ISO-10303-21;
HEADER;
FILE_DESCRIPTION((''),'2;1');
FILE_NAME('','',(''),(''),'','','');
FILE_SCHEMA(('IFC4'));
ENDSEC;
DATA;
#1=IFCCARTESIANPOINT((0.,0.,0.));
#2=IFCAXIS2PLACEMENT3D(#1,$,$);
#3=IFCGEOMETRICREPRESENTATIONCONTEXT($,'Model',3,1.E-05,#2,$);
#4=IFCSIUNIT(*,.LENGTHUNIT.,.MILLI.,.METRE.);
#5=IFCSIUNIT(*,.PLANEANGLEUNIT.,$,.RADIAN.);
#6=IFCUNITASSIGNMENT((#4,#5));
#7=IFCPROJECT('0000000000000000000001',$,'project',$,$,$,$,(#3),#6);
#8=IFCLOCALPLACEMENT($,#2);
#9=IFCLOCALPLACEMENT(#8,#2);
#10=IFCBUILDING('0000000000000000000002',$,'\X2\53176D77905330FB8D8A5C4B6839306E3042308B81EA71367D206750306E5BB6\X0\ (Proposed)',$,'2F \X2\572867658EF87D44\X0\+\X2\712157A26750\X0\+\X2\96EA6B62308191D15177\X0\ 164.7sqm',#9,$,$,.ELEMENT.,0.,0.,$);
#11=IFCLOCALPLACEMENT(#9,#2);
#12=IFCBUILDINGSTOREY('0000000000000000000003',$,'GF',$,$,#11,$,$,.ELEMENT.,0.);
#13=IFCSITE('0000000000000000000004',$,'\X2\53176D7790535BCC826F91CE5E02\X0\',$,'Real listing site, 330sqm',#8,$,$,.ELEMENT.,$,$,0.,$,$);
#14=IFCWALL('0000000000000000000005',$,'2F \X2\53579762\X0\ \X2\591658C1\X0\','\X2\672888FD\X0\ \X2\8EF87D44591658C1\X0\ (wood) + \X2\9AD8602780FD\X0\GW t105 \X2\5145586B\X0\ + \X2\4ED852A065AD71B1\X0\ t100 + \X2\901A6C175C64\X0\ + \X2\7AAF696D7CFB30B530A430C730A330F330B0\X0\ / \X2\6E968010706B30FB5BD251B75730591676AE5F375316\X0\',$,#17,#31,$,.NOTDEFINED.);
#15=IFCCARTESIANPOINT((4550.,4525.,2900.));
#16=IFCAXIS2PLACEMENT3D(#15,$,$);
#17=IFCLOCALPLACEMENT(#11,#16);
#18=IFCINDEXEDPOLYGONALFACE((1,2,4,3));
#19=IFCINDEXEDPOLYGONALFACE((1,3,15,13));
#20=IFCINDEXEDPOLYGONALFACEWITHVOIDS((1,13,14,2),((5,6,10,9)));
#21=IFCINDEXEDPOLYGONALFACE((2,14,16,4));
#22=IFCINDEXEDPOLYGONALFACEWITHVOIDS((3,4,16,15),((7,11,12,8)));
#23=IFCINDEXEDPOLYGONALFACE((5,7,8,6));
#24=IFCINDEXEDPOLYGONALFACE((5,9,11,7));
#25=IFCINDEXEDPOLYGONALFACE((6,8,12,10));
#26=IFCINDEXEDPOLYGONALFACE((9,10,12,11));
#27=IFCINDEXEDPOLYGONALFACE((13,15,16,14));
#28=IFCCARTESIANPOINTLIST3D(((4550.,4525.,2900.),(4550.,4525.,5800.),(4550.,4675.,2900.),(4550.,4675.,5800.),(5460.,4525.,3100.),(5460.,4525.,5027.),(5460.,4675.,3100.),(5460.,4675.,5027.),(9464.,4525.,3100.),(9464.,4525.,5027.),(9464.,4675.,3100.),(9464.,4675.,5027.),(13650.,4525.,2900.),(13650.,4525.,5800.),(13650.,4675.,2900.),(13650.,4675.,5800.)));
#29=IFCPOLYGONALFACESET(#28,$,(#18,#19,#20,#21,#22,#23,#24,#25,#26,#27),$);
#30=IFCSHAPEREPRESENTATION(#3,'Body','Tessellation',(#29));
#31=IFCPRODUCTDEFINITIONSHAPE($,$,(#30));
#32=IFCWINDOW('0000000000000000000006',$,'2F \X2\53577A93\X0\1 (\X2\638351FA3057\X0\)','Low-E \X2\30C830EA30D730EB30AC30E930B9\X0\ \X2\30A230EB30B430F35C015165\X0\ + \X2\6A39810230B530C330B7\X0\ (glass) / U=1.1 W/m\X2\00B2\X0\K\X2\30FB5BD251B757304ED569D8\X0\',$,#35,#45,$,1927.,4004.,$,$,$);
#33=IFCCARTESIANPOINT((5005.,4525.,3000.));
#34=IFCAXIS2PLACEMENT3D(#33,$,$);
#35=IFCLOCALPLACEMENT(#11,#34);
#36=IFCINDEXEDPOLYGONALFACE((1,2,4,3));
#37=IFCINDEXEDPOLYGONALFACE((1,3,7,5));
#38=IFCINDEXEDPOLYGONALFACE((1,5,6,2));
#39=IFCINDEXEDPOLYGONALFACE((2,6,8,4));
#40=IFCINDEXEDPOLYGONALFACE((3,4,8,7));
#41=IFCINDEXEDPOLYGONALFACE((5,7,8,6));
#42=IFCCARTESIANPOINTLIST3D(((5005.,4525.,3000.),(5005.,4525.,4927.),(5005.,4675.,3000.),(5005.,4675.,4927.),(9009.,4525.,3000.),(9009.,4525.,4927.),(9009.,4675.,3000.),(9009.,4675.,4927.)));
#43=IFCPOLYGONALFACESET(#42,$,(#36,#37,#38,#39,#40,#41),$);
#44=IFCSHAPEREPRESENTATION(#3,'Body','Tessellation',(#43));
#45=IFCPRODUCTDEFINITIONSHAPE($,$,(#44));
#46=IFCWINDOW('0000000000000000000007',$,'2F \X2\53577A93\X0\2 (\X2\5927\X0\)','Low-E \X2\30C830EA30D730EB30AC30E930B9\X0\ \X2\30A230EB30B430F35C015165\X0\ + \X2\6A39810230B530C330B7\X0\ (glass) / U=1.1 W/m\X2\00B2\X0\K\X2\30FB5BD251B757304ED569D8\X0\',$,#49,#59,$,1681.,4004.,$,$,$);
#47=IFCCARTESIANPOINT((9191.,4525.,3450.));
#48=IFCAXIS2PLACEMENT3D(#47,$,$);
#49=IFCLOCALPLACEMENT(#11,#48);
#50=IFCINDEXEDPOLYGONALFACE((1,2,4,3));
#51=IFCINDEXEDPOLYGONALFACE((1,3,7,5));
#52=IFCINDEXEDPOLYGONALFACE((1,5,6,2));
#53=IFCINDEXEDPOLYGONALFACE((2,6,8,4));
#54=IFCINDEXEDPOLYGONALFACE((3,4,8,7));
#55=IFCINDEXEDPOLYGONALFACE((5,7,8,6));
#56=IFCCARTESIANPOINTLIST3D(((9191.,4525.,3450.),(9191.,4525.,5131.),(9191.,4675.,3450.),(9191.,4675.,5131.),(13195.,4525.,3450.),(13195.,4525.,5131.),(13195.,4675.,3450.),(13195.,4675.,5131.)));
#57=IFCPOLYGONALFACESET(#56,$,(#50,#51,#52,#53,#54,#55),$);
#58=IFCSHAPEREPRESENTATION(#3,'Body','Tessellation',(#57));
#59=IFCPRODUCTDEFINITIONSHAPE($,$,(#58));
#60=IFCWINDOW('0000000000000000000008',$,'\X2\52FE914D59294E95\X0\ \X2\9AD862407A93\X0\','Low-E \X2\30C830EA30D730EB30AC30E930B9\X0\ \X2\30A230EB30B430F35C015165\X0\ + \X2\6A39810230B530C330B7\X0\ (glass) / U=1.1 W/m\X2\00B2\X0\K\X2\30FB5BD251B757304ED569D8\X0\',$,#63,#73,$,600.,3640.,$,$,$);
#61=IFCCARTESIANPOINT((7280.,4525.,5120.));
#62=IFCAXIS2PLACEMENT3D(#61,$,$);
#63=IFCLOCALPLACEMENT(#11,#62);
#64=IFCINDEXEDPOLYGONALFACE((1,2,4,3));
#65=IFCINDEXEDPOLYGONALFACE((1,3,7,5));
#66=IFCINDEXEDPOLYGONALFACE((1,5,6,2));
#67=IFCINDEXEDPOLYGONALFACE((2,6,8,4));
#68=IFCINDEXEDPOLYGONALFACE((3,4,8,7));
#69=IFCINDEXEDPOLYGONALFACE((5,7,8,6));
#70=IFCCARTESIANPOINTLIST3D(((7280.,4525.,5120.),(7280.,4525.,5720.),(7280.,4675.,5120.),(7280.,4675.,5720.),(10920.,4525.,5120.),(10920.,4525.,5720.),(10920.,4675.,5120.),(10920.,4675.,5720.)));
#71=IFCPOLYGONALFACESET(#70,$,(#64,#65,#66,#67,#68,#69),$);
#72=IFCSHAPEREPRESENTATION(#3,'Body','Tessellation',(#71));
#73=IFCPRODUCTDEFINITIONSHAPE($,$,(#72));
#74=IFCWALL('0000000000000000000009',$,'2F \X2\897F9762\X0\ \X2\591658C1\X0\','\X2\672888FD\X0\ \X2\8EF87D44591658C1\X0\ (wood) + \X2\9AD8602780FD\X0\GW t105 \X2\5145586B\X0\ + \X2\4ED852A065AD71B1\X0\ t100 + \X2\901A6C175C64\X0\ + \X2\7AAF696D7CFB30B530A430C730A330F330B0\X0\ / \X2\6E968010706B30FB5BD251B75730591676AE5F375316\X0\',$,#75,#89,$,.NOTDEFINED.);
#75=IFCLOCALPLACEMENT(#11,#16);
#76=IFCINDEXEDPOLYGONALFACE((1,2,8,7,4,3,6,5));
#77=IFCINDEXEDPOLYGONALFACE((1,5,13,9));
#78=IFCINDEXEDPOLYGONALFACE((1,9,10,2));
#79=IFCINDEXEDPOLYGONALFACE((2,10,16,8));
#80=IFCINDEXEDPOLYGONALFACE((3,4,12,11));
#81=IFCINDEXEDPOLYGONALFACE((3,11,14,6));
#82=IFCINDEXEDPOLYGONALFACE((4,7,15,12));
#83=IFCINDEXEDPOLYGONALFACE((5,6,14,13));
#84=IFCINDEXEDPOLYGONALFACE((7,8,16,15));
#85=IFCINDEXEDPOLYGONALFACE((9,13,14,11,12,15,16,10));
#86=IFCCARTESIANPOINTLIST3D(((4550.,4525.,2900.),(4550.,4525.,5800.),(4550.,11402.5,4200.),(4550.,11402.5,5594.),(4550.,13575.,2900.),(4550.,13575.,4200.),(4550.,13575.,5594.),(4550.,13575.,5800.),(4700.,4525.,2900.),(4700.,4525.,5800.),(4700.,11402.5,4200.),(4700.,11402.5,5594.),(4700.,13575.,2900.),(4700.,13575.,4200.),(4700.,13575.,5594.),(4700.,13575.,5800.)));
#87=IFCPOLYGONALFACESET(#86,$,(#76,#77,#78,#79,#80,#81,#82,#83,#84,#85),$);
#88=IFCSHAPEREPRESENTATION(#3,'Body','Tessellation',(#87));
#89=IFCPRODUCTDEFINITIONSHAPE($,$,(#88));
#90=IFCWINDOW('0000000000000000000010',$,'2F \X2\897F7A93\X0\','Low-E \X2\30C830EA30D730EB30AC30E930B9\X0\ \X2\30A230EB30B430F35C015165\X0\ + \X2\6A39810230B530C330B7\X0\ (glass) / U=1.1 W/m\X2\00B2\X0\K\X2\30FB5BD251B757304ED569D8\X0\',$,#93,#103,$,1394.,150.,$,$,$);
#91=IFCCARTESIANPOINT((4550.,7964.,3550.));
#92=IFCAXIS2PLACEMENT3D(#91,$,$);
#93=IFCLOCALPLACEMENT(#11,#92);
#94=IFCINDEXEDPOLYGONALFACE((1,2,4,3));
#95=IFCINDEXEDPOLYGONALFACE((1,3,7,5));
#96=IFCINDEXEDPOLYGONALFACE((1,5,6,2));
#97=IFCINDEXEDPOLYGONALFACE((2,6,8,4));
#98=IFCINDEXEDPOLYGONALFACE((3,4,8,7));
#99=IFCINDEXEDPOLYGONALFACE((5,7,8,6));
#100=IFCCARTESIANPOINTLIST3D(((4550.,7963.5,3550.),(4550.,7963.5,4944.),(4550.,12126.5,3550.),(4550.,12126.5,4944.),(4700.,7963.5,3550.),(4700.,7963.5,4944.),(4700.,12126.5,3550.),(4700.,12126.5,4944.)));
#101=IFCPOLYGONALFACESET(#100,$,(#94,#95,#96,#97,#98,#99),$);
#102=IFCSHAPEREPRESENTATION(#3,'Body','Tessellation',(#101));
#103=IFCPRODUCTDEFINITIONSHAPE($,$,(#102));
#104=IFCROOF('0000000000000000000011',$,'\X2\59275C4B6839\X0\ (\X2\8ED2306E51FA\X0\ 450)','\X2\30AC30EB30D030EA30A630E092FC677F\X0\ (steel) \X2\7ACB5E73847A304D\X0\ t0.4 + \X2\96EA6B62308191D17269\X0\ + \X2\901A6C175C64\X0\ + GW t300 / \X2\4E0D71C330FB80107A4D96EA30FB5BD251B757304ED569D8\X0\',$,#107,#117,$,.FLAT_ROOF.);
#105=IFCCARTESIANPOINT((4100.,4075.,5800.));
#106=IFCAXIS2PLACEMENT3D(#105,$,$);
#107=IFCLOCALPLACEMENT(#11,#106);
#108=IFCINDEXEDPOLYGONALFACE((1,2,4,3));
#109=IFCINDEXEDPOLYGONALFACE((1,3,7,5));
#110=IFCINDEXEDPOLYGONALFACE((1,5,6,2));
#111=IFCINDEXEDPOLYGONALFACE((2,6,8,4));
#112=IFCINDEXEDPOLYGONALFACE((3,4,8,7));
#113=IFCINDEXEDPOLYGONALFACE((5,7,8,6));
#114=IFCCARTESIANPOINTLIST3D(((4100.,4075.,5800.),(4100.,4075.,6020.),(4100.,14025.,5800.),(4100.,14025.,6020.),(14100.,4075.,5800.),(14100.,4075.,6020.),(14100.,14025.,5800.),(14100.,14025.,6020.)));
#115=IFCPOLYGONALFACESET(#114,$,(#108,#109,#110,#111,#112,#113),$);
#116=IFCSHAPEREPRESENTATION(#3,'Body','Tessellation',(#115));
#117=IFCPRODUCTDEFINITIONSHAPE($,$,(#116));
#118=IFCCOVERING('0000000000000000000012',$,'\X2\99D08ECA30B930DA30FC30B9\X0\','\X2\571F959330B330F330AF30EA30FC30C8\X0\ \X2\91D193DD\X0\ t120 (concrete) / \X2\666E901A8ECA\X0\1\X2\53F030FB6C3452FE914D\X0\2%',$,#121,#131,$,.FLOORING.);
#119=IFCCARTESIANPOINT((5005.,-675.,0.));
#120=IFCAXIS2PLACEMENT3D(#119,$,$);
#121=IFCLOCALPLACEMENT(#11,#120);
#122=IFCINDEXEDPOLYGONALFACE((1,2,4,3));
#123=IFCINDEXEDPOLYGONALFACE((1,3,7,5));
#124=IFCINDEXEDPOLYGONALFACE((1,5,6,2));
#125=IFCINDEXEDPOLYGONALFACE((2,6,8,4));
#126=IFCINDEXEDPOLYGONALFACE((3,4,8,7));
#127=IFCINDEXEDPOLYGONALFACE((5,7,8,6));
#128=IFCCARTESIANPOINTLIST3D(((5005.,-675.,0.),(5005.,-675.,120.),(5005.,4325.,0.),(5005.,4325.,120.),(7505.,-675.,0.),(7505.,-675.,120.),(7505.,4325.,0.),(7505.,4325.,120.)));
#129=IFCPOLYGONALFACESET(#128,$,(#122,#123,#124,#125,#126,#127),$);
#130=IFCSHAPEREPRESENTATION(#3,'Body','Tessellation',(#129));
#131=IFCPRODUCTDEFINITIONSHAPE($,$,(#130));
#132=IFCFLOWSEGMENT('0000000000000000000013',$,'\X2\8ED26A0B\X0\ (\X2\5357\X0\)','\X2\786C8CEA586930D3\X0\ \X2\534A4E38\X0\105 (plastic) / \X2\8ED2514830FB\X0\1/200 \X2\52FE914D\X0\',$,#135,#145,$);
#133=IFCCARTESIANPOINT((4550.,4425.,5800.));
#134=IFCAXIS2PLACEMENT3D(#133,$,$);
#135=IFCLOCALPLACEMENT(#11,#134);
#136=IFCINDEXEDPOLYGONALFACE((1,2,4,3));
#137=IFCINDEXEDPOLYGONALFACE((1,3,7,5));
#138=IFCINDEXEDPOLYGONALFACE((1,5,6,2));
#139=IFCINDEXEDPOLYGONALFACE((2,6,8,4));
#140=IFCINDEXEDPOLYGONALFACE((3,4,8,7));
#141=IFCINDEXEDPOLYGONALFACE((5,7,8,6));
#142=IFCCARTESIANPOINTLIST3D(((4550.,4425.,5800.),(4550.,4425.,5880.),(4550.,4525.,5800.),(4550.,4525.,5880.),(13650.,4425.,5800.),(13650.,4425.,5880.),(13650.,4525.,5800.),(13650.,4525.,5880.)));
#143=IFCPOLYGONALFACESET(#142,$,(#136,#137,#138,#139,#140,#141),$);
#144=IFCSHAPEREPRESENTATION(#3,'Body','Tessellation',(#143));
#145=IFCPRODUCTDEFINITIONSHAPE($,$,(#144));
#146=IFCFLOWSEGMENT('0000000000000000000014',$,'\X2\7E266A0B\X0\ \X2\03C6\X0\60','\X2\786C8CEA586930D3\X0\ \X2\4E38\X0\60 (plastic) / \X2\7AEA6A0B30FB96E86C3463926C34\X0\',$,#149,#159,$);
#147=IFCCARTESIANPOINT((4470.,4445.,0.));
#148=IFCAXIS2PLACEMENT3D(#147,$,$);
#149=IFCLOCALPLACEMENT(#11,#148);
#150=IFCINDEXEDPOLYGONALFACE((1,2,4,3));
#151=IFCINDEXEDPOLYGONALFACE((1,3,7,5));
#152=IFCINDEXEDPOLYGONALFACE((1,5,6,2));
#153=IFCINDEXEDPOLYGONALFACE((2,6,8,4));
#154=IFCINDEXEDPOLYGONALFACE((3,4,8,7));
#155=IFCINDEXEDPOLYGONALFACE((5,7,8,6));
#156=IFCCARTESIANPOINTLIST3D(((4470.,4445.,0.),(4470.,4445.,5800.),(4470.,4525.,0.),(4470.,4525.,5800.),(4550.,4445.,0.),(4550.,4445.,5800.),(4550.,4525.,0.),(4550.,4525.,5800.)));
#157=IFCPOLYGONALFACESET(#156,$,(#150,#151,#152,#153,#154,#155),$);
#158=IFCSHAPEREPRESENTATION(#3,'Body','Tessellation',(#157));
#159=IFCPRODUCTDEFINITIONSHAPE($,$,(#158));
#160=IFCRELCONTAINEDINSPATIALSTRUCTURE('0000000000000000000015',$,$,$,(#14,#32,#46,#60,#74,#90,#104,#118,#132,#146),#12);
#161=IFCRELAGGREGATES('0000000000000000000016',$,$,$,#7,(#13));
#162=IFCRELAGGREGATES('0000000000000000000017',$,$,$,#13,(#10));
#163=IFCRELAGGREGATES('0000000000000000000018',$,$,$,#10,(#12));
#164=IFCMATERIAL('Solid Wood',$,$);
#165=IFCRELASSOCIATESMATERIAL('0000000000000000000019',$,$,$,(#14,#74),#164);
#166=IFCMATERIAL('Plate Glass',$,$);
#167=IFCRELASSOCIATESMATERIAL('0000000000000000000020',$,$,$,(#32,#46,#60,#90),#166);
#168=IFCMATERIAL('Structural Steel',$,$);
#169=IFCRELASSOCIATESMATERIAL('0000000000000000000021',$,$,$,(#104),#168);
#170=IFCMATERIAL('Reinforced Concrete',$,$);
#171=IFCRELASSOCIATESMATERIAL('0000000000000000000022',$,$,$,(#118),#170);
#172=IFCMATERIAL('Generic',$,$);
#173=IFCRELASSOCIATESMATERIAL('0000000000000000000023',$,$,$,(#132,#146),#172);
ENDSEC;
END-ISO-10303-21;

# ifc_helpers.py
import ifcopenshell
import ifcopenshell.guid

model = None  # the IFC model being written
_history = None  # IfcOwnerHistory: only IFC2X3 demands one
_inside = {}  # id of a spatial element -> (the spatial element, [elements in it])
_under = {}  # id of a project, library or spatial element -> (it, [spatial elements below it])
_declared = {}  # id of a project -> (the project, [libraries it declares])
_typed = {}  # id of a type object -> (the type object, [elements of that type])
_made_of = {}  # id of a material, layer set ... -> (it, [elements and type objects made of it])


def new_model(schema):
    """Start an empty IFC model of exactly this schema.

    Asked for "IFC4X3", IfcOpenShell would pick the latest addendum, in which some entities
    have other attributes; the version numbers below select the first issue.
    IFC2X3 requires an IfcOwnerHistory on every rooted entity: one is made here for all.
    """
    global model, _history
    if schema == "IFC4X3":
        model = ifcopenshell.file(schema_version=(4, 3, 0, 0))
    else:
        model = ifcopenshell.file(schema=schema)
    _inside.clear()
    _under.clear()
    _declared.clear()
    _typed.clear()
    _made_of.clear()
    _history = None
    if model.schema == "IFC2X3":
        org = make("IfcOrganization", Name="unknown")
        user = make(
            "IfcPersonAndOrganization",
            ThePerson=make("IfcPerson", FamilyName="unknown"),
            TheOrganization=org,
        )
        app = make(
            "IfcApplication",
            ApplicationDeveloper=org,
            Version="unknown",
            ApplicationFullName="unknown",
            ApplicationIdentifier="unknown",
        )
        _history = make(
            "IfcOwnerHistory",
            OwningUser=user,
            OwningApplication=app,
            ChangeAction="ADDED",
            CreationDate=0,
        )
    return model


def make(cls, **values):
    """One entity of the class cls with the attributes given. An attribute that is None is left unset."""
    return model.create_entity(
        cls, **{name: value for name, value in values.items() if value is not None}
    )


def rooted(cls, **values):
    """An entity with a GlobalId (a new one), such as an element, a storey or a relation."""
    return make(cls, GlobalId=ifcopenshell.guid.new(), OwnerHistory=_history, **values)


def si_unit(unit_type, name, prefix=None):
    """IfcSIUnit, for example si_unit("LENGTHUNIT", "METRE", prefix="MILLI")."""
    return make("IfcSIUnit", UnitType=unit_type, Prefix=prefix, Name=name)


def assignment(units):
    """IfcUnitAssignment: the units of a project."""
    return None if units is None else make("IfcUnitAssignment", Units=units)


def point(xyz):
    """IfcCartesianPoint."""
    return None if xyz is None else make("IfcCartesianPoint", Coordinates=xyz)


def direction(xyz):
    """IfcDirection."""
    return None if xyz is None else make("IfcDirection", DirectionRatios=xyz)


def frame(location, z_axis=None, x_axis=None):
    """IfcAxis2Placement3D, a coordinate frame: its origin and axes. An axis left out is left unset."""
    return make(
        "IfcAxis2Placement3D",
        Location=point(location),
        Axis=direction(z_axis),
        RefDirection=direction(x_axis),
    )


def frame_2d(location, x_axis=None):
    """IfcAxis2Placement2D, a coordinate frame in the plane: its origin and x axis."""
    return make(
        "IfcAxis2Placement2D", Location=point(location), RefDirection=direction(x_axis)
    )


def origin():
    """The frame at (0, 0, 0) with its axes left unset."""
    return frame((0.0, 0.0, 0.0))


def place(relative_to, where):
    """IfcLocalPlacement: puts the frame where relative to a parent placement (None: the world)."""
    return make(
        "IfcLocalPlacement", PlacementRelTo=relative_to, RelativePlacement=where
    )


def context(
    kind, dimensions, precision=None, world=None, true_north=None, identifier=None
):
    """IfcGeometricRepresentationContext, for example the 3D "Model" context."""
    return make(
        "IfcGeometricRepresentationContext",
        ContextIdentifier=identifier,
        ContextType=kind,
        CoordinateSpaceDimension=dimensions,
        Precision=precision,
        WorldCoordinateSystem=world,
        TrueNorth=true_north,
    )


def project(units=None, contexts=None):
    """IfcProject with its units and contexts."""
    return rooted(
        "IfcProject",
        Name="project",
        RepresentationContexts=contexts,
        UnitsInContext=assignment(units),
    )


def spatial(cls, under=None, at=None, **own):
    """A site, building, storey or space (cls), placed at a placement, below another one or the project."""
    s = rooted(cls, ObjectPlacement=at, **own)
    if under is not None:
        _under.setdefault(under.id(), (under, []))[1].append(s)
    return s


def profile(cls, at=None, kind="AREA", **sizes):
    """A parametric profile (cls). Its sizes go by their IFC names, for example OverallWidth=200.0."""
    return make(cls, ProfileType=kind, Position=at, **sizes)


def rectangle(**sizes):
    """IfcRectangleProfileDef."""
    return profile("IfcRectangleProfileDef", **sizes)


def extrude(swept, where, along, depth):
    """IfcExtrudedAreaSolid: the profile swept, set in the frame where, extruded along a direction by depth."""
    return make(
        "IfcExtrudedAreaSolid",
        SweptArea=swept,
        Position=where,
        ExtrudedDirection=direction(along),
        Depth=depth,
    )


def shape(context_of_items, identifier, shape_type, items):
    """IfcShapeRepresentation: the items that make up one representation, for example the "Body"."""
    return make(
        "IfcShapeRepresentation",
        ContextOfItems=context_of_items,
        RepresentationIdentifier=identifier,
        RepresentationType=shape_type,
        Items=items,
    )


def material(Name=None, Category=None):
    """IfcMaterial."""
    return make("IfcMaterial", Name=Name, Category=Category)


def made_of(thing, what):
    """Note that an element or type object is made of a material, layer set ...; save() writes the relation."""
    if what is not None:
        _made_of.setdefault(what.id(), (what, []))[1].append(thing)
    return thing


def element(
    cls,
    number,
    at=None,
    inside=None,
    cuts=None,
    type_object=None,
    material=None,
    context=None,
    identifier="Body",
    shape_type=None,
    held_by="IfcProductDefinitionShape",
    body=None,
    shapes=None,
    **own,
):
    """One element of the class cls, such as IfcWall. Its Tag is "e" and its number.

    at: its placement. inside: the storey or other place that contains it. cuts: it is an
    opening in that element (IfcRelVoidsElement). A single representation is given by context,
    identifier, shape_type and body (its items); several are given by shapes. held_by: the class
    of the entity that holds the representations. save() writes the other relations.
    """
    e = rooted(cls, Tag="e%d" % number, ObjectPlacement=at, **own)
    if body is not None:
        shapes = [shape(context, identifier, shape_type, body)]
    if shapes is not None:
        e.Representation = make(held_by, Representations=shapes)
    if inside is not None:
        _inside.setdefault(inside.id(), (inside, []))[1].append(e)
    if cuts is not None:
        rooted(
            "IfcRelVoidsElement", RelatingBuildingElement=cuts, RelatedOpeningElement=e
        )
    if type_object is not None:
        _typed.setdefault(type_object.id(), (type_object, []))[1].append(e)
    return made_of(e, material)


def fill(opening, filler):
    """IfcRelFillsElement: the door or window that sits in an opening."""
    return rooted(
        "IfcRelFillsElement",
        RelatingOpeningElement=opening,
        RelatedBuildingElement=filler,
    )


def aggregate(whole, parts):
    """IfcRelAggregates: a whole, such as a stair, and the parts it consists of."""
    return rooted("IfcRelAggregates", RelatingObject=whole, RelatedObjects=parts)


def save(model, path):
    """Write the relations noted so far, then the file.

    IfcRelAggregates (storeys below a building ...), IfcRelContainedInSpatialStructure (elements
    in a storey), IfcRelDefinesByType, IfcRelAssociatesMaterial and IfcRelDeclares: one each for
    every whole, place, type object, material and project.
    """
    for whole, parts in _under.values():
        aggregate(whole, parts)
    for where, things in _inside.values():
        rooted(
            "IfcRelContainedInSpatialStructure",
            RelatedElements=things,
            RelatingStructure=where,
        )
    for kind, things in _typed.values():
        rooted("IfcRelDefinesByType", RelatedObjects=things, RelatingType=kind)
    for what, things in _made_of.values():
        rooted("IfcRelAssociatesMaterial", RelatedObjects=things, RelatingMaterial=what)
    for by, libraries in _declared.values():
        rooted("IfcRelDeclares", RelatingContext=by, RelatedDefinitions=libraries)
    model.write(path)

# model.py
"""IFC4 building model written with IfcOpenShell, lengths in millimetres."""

from ifc_helpers import new_model, si_unit, frame, frame_2d, origin, place, context, project, spatial, rectangle, extrude, material, element, fill, save


model = new_model("IFC4")

# Units and contexts
model_context = context("Model", 3, precision=1e-05, world=origin())
ifc_project = project(units=[si_unit("LENGTHUNIT", "METRE", prefix="MILLI"), si_unit("PLANEANGLEUNIT", "RADIAN")], contexts=[model_context])

# Site, building, storey
site_placement = place(None, origin())
site = spatial("IfcSite", under=ifc_project, at=site_placement, Name="北海道富良野市", ObjectType="Real listing site, 330sqm", CompositionType="ELEMENT", RefElevation=0.0)
building_placement = place(site_placement, origin())
building = spatial("IfcBuilding", under=site, at=building_placement, Name="北海道・越屋根のある自然素材の家 (Proposed)", ObjectType="2F 在来軸組+無垢材+雪止め金具 164.7sqm", CompositionType="ELEMENT", ElevationOfRefHeight=0.0, ElevationOfTerrain=0.0)
storey_placement = place(building_placement, origin())
storey = spatial("IfcBuildingStorey", under=building, at=storey_placement, Name="GF", CompositionType="ELEMENT", Elevation=0.0)

# Shared definitions
ifc_material_1 = material(Name="Solid Wood")

# Shared definitions
ifc_material_2 = material(Name="Reinforced Concrete")

# Shared definitions
ifc_material_3 = material(Name="Plate Glass")

# Wall, openings, windows
wall_1_placement = place(storey_placement, frame((4550.0, 4525.0, 2900.0)))
wall_1 = element("IfcWall", 1, at=wall_1_placement, inside=storey, material=ifc_material_1, Name="2F 南面 外壁", Description="木製 軸組外壁 (wood) + 高性能GW t105 充填 + 付加断熱 t100 + 通気層 + 窯業系サイディング / 準耐火・寒冷地外皮強化", PredefinedType="NOTDEFINED", context=model_context, shape_type="SweptSolid", body=[
    extrude(rectangle(XDim=9100.0, YDim=150.0, at=frame_2d((4550.0, 75.0))), frame((4550.0, 4525.0, 2900.0)), (0.0, 0.0, 1.0), 2900.0),
])
opening_1_placement = place(storey_placement, frame((5005.0, 4525.0, 3000.0)))
opening_1 = element("IfcOpeningElement", 2, at=opening_1_placement, cuts=wall_1, PredefinedType="NOTDEFINED", context=model_context, shape_type="SweptSolid", body=[
    extrude(rectangle(XDim=4004.0, YDim=150.0, at=frame_2d((2002.0, 75.0))), frame((5005.0, 4525.0, 3000.0)), (0.0, 0.0, 1.0), 1927.0),
])
opening_2_placement = place(storey_placement, frame((9191.0, 4525.0, 3450.0)))
opening_2 = element("IfcOpeningElement", 3, at=opening_2_placement, cuts=wall_1, PredefinedType="NOTDEFINED", context=model_context, shape_type="SweptSolid", body=[
    extrude(rectangle(XDim=4004.0, YDim=150.0, at=frame_2d((2002.0, 75.0))), frame((9191.0, 4525.0, 3450.0)), (0.0, 0.0, 1.0), 1681.0),
])
opening_3_placement = place(storey_placement, frame((7280.0, 4525.0, 5120.0)))
opening_3 = element("IfcOpeningElement", 4, at=opening_3_placement, cuts=wall_1, PredefinedType="NOTDEFINED", context=model_context, shape_type="SweptSolid", body=[
    extrude(rectangle(XDim=3640.0, YDim=150.0, at=frame_2d((1820.0, 75.0))), frame((7280.0, 4525.0, 5120.0)), (0.0, 0.0, 1.0), 600.0),
])
window_1_placement = place(storey_placement, frame((5005.0, 4525.0, 3000.0)))
window_1 = element("IfcWindow", 5, at=window_1_placement, inside=storey, material=ifc_material_3, Name="2F 南窓1 (掃出し)", Description="Low-E トリプルガラス アルゴン封入 + 樹脂サッシ (glass) / U=1.1 W/m²K・寒冷地仕様", OverallHeight=1927.0, OverallWidth=4004.0, context=model_context, shape_type="SweptSolid", body=[
    extrude(rectangle(XDim=4004.0, YDim=150.0, at=frame_2d((2002.0, 75.0))), frame((5005.0, 4525.0, 3000.0)), (0.0, 0.0, 1.0), 1927.0),
])
fill(opening_1, window_1)
window_2_placement = place(storey_placement, frame((9191.0, 4525.0, 3450.0)))
window_2 = element("IfcWindow", 6, at=window_2_placement, inside=storey, material=ifc_material_3, Name="2F 南窓2 (大)", Description="Low-E トリプルガラス アルゴン封入 + 樹脂サッシ (glass) / U=1.1 W/m²K・寒冷地仕様", OverallHeight=1681.0, OverallWidth=4004.0, context=model_context, shape_type="SweptSolid", body=[
    extrude(rectangle(XDim=4004.0, YDim=150.0, at=frame_2d((2002.0, 75.0))), frame((9191.0, 4525.0, 3450.0)), (0.0, 0.0, 1.0), 1681.0),
])
fill(opening_2, window_2)
window_3_placement = place(storey_placement, frame((7280.0, 4525.0, 5120.0)))
window_3 = element("IfcWindow", 7, at=window_3_placement, inside=storey, material=ifc_material_3, Name="勾配天井 高所窓", Description="Low-E トリプルガラス アルゴン封入 + 樹脂サッシ (glass) / U=1.1 W/m²K・寒冷地仕様", OverallHeight=600.0, OverallWidth=3640.0, context=model_context, shape_type="SweptSolid", body=[
    extrude(rectangle(XDim=3640.0, YDim=150.0, at=frame_2d((1820.0, 75.0))), frame((7280.0, 4525.0, 5120.0)), (0.0, 0.0, 1.0), 600.0),
])
fill(opening_3, window_3)

# Wall, opening, window
wall_2_placement = place(storey_placement, frame((4550.0, 4525.0, 2900.0)))
wall_2 = element("IfcWall", 8, at=wall_2_placement, inside=storey, material=ifc_material_1, Name="2F 西面 外壁", Description="木製 軸組外壁 (wood) + 高性能GW t105 充填 + 付加断熱 t100 + 通気層 + 窯業系サイディング / 準耐火・寒冷地外皮強化", PredefinedType="NOTDEFINED", context=model_context, shape_type="SweptSolid", body=[
    extrude(rectangle(XDim=150.0, YDim=9050.0, at=frame_2d((75.0, 4525.0))), frame((4550.0, 4525.0, 2900.0)), (0.0, 0.0, 1.0), 2900.0),
])
opening_4_placement = place(storey_placement, frame((4550.0, 7964.0, 3550.0)))
opening_4 = element("IfcOpeningElement", 9, at=opening_4_placement, cuts=wall_2, PredefinedType="NOTDEFINED", context=model_context, shape_type="SweptSolid", body=[
    extrude(rectangle(XDim=150.0, YDim=4163.0, at=frame_2d((75.0, 2081.0))), frame((4550.0, 7964.0, 3550.0)), (0.0, 0.0, 1.0), 1394.0),
])
window_4_placement = place(storey_placement, frame((4550.0, 7964.0, 3550.0)))
window_4 = element("IfcWindow", 10, at=window_4_placement, inside=storey, material=ifc_material_3, Name="2F 西窓", Description="Low-E トリプルガラス アルゴン封入 + 樹脂サッシ (glass) / U=1.1 W/m²K・寒冷地仕様", OverallHeight=1394.0, OverallWidth=150.0, context=model_context, shape_type="SweptSolid", body=[
    extrude(rectangle(XDim=150.0, YDim=4163.0, at=frame_2d((75.0, 2081.0))), frame((4550.0, 7964.0, 3550.0)), (0.0, 0.0, 1.0), 1394.0),
])
fill(opening_4, window_4)

# Roof
ifc_material_4 = material(Name="Structural Steel")
roof_placement = place(storey_placement, frame((4100.0, 4075.0, 5800.0)))
element("IfcRoof", 11, at=roof_placement, inside=storey, material=ifc_material_4, Name="大屋根 (軒の出 450)", Description="ガルバリウム鋼板 (steel) 立平葺き t0.4 + 雪止め金物 + 通気層 + GW t300 / 不燃・耐積雪・寒冷地仕様", PredefinedType="FLAT_ROOF", context=model_context, shape_type="SweptSolid", body=[
    extrude(rectangle(XDim=10000.0, YDim=9950.0, at=frame_2d((5000.0, 4975.0))), frame((4100.0, 4075.0, 5800.0)), (0.0, 0.0, 1.0), 220.0),
])

# Covering
covering_placement = place(storey_placement, frame((5005.0, -675.0, 0.0)))
element("IfcCovering", 12, at=covering_placement, inside=storey, material=ifc_material_2, Name="駐車スペース", Description="土間コンクリート 金鏝 t120 (concrete) / 普通車1台・水勾配2%", PredefinedType="FLOORING", context=model_context, shape_type="SweptSolid", body=[
    extrude(rectangle(XDim=2500.0, YDim=5000.0, at=frame_2d((1250.0, 2500.0))), frame((5005.0, -675.0, 0.0)), (0.0, 0.0, 1.0), 120.0),
])

# Flow segments
ifc_material_5 = material(Name="Generic")
flow_segment_1_placement = place(storey_placement, frame((4550.0, 4425.0, 5800.0)))
element("IfcFlowSegment", 13, at=flow_segment_1_placement, inside=storey, material=ifc_material_5, Name="軒樋 (南)", Description="硬質塩ビ 半丸105 (plastic) / 軒先・1/200 勾配", context=model_context, shape_type="SweptSolid", body=[
    extrude(rectangle(XDim=9100.0, YDim=100.0, at=frame_2d((4550.0, 50.0))), frame((4550.0, 4425.0, 5800.0)), (0.0, 0.0, 1.0), 80.0),
])
flow_segment_2_placement = place(storey_placement, frame((4470.0, 4445.0, 0.0)))
element("IfcFlowSegment", 14, at=flow_segment_2_placement, inside=storey, material=ifc_material_5, Name="縦樋 φ60", Description="硬質塩ビ 丸60 (plastic) / 竪樋・雨水排水", context=model_context, shape_type="SweptSolid", body=[
    extrude(rectangle(XDim=80.0, YDim=80.0, at=frame_2d((40.0, 40.0))), frame((4470.0, 4445.0, 0.0)), (0.0, 0.0, 1.0), 5800.0),
])

save(model, "model.ifc")
